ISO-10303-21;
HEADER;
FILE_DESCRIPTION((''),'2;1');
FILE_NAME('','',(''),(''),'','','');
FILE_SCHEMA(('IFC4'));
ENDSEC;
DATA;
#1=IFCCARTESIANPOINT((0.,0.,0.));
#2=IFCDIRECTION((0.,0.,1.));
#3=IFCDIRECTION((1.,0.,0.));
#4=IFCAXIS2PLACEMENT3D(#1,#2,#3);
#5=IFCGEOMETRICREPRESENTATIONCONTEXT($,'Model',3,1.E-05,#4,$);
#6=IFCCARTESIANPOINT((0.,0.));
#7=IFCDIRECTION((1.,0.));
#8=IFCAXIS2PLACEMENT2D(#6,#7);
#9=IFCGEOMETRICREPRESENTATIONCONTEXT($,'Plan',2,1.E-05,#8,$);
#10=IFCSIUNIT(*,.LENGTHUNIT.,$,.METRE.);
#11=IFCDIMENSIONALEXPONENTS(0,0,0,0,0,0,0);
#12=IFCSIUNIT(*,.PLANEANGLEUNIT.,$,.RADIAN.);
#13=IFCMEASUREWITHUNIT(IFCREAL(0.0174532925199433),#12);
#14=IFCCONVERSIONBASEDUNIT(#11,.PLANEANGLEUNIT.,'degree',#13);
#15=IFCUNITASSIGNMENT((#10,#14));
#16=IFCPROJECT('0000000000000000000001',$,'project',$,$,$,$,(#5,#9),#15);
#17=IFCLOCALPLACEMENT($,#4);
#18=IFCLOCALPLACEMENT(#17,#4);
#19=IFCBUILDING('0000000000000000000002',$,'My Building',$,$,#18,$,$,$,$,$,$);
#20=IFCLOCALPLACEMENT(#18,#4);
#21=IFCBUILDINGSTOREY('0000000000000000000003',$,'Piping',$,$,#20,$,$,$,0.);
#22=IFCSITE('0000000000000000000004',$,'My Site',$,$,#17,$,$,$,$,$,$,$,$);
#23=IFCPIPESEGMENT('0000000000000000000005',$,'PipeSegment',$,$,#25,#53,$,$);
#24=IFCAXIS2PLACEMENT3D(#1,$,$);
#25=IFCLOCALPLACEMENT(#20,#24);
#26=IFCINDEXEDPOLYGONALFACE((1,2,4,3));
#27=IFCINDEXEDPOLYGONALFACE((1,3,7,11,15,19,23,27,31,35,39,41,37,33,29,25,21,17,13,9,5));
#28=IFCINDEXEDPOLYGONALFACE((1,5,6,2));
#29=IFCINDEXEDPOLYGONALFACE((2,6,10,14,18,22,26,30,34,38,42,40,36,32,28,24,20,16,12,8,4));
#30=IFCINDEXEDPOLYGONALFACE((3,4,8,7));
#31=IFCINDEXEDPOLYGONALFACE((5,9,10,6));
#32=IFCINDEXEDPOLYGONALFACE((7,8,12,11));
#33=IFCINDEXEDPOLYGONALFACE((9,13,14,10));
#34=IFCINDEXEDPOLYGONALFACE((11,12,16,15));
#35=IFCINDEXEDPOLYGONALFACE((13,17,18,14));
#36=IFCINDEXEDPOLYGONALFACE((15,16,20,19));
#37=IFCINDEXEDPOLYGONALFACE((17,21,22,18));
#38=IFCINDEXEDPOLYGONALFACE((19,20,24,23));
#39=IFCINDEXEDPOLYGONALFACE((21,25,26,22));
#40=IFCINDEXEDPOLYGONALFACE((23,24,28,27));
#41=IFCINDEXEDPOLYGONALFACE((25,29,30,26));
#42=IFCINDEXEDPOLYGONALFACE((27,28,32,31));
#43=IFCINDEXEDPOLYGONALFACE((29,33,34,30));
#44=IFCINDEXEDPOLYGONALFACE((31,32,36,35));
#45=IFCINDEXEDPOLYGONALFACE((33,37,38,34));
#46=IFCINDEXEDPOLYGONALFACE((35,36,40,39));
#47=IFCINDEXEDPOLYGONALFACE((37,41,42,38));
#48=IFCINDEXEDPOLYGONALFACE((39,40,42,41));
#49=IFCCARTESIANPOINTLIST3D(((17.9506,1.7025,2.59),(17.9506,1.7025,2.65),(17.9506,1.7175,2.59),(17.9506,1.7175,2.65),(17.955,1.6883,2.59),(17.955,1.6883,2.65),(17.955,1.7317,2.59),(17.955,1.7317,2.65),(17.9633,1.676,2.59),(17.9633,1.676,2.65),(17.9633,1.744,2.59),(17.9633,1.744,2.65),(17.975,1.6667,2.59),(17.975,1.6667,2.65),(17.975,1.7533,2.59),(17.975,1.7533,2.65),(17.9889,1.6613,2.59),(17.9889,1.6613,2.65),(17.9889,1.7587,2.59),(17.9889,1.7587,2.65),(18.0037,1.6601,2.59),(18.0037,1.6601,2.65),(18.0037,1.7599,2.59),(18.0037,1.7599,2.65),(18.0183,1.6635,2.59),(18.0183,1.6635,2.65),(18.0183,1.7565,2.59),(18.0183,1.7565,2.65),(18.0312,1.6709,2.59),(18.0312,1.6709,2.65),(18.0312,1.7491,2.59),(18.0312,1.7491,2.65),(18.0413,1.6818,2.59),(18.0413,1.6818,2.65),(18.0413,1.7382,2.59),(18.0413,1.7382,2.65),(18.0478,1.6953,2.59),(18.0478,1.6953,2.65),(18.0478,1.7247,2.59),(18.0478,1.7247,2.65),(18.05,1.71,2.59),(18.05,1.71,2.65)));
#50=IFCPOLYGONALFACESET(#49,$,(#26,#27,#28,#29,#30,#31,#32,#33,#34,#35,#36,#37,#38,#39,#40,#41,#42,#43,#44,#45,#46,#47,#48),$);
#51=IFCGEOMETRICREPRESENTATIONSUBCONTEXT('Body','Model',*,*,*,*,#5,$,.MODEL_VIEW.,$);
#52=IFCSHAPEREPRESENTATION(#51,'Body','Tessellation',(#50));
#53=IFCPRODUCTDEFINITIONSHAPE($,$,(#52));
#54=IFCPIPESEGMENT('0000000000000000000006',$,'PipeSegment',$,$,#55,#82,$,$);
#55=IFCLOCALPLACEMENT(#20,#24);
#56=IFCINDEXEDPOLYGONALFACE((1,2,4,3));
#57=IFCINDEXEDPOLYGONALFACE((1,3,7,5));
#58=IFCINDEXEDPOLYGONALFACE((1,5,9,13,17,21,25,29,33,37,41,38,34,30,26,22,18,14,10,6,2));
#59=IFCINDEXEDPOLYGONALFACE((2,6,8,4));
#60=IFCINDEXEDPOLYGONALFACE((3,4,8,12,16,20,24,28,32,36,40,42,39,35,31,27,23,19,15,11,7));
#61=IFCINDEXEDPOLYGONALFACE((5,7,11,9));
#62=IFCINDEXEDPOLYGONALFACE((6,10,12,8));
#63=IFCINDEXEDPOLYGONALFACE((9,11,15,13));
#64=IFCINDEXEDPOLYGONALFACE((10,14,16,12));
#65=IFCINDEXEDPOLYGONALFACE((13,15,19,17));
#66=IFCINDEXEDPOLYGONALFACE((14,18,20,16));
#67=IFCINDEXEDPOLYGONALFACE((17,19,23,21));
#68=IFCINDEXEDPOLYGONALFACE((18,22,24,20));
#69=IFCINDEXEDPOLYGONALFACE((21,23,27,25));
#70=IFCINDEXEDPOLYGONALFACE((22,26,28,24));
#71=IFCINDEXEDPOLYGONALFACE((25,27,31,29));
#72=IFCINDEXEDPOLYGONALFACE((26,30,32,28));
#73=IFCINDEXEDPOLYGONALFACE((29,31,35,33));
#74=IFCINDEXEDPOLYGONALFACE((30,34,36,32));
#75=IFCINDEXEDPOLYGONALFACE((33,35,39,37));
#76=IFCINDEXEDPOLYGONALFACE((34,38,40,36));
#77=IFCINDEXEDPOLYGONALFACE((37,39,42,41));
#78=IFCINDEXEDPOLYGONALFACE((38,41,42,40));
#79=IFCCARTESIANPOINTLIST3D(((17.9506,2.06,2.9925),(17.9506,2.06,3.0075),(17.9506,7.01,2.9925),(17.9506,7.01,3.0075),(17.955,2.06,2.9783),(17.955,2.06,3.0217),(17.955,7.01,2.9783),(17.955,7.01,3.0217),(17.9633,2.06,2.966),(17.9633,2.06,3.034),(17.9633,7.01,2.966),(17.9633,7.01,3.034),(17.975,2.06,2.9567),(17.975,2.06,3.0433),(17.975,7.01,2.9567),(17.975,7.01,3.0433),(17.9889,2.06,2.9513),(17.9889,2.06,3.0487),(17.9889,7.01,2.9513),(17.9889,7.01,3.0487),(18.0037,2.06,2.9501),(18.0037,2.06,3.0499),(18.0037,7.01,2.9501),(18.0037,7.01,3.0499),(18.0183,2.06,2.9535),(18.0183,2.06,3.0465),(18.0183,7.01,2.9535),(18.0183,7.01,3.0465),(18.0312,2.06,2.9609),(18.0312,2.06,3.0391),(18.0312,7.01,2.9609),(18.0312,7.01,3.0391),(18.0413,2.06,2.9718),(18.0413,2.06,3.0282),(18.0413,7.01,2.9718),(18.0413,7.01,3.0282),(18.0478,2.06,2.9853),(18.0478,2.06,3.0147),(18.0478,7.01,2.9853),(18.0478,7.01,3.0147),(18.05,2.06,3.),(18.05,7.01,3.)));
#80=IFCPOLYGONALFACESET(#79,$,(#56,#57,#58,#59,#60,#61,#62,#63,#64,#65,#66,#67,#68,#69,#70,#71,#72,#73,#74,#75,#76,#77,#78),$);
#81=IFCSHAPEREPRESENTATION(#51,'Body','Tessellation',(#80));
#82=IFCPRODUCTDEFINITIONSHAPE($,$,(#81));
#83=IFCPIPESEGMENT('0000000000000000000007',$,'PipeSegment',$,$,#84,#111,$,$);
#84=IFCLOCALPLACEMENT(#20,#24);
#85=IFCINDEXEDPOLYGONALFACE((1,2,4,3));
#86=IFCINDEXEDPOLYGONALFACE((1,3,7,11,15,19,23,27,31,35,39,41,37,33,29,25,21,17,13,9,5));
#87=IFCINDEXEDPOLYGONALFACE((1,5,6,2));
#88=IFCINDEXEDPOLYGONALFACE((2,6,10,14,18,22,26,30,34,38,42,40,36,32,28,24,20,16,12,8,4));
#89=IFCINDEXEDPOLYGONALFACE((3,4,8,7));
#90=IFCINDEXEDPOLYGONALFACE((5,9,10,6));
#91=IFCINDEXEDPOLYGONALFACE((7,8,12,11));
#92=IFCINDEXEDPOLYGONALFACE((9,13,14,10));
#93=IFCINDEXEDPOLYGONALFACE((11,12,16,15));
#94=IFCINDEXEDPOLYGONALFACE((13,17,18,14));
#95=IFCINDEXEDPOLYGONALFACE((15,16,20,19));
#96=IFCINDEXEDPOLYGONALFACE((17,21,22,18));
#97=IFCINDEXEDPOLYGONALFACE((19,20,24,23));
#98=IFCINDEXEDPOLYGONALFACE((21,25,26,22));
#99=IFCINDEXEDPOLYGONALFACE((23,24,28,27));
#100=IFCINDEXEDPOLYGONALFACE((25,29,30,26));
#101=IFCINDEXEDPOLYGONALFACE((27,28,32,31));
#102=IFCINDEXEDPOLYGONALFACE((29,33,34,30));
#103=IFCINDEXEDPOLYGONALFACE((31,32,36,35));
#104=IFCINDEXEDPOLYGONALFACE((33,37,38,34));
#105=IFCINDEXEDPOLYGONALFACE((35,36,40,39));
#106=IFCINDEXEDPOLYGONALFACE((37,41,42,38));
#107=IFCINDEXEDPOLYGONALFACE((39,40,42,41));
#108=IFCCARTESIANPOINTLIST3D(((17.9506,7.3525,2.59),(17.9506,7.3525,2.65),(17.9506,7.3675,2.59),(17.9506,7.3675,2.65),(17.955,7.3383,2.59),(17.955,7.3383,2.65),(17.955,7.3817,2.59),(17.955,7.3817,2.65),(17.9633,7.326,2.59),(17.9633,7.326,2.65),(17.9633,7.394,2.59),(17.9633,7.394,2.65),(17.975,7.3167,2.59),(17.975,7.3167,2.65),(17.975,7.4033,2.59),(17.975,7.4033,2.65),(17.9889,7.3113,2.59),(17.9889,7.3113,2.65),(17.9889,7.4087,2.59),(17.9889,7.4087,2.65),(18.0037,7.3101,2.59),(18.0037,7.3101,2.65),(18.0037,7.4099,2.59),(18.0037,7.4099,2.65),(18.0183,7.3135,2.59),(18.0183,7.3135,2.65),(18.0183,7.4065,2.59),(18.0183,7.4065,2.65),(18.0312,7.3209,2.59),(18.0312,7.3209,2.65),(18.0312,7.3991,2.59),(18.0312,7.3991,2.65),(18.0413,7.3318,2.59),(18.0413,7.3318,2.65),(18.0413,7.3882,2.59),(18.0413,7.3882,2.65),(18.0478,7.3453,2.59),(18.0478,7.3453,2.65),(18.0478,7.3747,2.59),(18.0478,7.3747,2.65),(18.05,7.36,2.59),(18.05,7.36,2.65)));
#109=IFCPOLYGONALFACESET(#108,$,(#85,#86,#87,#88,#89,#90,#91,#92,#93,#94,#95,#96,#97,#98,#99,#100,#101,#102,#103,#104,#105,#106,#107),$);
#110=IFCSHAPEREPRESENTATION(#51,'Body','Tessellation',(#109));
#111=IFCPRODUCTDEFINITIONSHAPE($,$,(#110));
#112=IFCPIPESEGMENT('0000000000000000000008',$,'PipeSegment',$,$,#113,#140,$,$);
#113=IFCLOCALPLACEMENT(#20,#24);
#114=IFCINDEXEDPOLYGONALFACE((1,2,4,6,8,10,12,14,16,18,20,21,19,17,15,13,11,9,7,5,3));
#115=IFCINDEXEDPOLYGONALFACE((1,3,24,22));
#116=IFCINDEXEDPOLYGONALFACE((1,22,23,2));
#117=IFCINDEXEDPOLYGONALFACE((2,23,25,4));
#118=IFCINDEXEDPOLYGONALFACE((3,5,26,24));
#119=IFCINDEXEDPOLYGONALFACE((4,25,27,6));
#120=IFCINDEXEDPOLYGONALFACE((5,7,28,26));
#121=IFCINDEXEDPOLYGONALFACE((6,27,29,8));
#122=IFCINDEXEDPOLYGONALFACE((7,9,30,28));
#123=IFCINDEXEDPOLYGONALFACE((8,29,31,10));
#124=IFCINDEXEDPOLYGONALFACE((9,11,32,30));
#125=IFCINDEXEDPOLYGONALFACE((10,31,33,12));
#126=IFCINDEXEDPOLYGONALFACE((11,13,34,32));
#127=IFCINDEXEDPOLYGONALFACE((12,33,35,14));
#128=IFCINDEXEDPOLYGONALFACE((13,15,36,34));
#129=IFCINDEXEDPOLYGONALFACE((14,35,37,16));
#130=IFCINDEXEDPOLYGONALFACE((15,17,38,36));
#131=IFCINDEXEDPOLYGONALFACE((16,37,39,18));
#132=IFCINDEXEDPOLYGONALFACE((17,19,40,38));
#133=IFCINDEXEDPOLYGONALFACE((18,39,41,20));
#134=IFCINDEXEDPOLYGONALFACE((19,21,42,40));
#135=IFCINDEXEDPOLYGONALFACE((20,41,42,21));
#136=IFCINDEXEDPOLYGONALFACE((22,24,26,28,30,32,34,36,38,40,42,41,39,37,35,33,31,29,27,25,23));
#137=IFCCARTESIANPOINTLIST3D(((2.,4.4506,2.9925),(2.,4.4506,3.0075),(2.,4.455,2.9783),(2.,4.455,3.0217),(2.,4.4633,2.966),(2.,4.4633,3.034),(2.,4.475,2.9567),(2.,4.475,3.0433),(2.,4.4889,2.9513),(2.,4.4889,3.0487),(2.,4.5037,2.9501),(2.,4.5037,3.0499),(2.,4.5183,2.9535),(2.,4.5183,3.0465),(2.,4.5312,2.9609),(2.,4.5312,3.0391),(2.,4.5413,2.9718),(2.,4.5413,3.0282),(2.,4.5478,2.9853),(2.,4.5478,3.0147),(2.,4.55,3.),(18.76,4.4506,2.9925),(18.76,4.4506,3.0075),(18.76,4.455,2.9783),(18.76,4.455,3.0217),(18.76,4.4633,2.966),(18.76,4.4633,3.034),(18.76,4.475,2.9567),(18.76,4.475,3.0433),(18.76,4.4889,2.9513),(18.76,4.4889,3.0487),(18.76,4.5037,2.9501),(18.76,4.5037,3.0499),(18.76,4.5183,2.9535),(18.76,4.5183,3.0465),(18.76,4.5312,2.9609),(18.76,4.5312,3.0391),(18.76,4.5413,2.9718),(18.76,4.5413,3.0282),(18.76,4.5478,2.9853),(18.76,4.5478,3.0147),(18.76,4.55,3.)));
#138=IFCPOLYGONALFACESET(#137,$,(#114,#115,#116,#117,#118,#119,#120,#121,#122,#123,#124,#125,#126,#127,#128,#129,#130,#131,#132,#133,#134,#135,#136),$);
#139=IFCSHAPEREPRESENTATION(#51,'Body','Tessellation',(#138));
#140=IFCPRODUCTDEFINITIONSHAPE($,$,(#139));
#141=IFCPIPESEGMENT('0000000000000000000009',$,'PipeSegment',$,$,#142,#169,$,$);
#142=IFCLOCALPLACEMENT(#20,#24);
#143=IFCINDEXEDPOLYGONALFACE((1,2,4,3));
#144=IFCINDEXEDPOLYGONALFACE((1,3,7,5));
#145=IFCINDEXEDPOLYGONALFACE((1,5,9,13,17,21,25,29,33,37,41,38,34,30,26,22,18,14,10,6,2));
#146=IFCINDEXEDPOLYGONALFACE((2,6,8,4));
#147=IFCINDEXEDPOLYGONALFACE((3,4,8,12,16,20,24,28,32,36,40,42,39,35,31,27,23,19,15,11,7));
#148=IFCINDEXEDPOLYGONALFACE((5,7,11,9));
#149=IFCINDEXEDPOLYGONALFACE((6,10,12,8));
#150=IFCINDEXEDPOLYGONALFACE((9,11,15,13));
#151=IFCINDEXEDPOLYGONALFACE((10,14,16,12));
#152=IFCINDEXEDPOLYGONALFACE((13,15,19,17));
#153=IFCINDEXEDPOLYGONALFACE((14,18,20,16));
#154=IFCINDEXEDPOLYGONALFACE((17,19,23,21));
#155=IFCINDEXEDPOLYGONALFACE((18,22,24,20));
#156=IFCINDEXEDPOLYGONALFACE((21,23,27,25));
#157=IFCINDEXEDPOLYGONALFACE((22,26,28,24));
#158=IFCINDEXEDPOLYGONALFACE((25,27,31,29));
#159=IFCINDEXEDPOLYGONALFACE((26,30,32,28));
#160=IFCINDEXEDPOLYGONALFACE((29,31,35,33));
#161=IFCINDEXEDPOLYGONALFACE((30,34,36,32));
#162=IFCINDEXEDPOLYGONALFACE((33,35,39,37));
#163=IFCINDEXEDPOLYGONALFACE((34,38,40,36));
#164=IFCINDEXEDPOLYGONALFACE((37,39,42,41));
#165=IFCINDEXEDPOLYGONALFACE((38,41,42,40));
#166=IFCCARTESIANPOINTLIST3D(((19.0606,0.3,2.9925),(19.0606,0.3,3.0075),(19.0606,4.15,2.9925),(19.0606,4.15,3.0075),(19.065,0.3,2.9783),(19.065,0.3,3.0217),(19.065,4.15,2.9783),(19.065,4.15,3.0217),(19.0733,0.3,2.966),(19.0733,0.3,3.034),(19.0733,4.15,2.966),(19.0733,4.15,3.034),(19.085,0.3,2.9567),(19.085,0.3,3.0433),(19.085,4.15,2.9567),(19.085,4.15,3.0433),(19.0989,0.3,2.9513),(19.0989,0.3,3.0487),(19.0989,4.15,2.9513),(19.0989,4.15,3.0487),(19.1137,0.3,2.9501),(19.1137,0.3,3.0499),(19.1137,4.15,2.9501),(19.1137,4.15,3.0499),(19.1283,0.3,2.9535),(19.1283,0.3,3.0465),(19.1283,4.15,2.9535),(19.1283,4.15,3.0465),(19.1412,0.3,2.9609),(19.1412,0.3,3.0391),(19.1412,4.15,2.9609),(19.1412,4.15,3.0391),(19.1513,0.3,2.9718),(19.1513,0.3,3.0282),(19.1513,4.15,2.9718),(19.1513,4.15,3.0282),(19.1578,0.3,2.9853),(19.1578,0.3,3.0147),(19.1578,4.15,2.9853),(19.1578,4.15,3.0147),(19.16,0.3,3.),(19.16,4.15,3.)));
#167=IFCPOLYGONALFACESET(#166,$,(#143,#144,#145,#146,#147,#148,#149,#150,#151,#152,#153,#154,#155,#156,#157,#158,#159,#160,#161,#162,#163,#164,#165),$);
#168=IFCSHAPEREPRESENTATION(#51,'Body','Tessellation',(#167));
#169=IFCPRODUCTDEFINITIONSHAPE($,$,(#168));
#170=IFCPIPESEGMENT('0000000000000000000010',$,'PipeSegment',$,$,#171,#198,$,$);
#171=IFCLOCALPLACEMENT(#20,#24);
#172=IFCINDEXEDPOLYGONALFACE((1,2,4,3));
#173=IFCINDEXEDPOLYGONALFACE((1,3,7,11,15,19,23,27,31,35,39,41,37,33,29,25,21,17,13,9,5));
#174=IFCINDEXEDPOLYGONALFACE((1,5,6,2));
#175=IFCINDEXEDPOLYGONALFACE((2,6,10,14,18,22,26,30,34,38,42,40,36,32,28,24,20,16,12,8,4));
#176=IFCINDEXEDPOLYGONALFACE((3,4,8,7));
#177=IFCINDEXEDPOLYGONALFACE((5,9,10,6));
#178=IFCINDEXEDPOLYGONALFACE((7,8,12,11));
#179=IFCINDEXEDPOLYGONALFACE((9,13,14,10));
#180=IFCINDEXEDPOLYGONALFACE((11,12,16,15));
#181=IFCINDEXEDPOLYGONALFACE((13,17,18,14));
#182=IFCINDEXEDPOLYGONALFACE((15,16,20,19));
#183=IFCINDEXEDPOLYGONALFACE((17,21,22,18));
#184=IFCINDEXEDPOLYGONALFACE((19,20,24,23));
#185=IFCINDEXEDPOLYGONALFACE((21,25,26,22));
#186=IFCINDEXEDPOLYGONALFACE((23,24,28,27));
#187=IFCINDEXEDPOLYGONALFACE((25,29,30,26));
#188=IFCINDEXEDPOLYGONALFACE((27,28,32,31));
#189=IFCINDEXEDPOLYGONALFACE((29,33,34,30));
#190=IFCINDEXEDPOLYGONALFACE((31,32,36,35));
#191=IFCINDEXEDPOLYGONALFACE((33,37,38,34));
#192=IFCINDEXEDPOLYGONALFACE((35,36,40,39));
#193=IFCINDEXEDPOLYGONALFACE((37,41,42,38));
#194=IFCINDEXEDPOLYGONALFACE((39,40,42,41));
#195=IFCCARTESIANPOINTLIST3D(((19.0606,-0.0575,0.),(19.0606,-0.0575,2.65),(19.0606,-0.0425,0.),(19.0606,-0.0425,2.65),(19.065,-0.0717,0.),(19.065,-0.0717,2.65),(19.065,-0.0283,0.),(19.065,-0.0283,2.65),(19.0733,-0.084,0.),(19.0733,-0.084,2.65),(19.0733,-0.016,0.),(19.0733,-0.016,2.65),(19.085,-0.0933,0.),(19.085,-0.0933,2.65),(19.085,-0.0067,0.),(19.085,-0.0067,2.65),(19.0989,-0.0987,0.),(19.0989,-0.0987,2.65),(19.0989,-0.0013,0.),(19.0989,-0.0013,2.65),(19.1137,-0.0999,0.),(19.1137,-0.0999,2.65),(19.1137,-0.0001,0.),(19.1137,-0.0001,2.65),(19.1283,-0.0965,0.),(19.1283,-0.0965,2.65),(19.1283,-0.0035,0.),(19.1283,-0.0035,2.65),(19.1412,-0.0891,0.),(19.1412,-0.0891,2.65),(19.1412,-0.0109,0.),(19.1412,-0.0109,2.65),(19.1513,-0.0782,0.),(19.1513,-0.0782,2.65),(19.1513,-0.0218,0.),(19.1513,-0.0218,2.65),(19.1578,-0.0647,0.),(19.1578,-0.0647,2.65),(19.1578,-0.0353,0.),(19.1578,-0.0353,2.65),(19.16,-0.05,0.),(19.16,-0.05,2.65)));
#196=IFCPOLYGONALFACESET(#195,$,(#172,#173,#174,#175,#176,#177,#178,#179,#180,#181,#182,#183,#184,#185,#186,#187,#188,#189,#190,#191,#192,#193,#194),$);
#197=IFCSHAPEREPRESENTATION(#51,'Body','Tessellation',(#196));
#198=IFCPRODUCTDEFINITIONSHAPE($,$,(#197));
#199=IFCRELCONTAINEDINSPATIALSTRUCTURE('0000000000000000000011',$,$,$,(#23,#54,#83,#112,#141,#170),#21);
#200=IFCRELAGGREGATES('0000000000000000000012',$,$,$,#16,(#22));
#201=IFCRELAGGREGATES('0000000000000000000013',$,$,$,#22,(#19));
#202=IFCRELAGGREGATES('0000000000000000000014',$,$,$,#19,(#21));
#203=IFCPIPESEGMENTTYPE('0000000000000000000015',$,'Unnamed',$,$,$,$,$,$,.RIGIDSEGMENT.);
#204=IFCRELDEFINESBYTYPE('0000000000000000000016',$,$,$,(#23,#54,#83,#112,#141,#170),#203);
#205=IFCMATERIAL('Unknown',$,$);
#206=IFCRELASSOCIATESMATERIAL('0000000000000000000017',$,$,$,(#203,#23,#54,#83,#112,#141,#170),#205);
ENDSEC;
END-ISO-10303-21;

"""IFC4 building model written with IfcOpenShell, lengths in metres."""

from ifc_helpers import new_model, entity, si_unit, converted_unit, frame, origin_with_axes, origin_2d_with_axis, place, context, subcontext, project, spatial, circle, extrude, material, material_profile, profile_set, profile_usage, type_object, element, save


model = new_model("IFC4")

# Units and contexts
model_context = context("Model", 3, precision=1e-05, world=origin_with_axes())
plan_context = context("Plan", 2, precision=1e-05, world=origin_2d_with_axis())
body_context = subcontext(model_context, "Body", "Model", "MODEL_VIEW")
ifc_project = project(units=[si_unit("LENGTHUNIT", "METRE"), converted_unit("PLANEANGLEUNIT", "degree", entity("IfcReal", 0.0174532925199433), si_unit("PLANEANGLEUNIT", "RADIAN"), dimensions=[0, 0, 0, 0, 0, 0, 0])], contexts=[model_context, plan_context])

# Site, building, storey
site_placement = place(None, origin_with_axes())
site = spatial("IfcSite", under=ifc_project, at=site_placement, Name="My Site")
building_placement = place(site_placement, origin_with_axes())
building = spatial("IfcBuilding", under=site, at=building_placement, Name="My Building")
storey_placement = place(building_placement, origin_with_axes())
storey = spatial("IfcBuildingStorey", under=building, at=storey_placement, Name="Piping", Elevation=0.0)

# Pipe segments
ifc_material = material(Name="Unknown")
ifc_material_profile = material_profile(ifc_material, circle(Radius=0.05))
ifc_profile_set = profile_set([ifc_material_profile])
pipe_segment_type = type_object("IfcPipeSegmentType", Name="Unnamed", PredefinedType="RIGIDSEGMENT", material=ifc_profile_set)
ifc_profile_usage_1 = profile_usage(ifc_profile_set)
pipe_segment_1_placement = place(storey_placement, frame((18.0, 1.71, 2.59), z_axis=(0.0, 0.0, 1.0), x_axis=(1.0, 0.0, 0.0)))
element("IfcPipeSegment", 1, at=pipe_segment_1_placement, inside=storey, type_object=pipe_segment_type, material=ifc_profile_usage_1, Name="PipeSegment", context=body_context, shape_type="SweptSolid", body=[
    extrude(circle(Radius=0.05), origin_with_axes(), (0.0, 0.0, 1.0), 0.06),
])
ifc_profile_usage_2 = profile_usage(ifc_profile_set)
pipe_segment_2_placement = place(storey_placement, frame((18.0, 2.06, 3.0), z_axis=(0.0, 1.0, 0.0), x_axis=(1.0, 0.0, 0.0)))
element("IfcPipeSegment", 2, at=pipe_segment_2_placement, inside=storey, type_object=pipe_segment_type, material=ifc_profile_usage_2, Name="PipeSegment", context=body_context, shape_type="SweptSolid", body=[
    extrude(circle(Radius=0.05), origin_with_axes(), (0.0, 0.0, 1.0), 4.95),
])
ifc_profile_usage_3 = profile_usage(ifc_profile_set)
pipe_segment_3_placement = place(storey_placement, frame((18.0, 7.36, 2.65), z_axis=(0.0, 0.0, -1.0), x_axis=(1.0, 0.0, 0.0)))
element("IfcPipeSegment", 3, at=pipe_segment_3_placement, inside=storey, type_object=pipe_segment_type, material=ifc_profile_usage_3, Name="PipeSegment", context=body_context, shape_type="SweptSolid", body=[
    extrude(circle(Radius=0.05), origin_with_axes(), (0.0, 0.0, 1.0), 0.06),
])
ifc_profile_usage_4 = profile_usage(ifc_profile_set)
pipe_segment_4_placement = place(storey_placement, frame((2.0, 4.5, 3.0), z_axis=(1.0, 0.0, 0.0), x_axis=(0.0, 1.0, 0.0)))
element("IfcPipeSegment", 4, at=pipe_segment_4_placement, inside=storey, type_object=pipe_segment_type, material=ifc_profile_usage_4, Name="PipeSegment", context=body_context, shape_type="SweptSolid", body=[
    extrude(circle(Radius=0.05), origin_with_axes(), (0.0, 0.0, 1.0), 16.76),
])
ifc_profile_usage_5 = profile_usage(ifc_profile_set)
pipe_segment_5_placement = place(storey_placement, frame((19.11, 4.15, 3.0), z_axis=(0.0, -1.0, 0.0), x_axis=(1.0, 0.0, 0.0)))
element("IfcPipeSegment", 5, at=pipe_segment_5_placement, inside=storey, type_object=pipe_segment_type, material=ifc_profile_usage_5, Name="PipeSegment", context=body_context, shape_type="SweptSolid", body=[
    extrude(circle(Radius=0.05), origin_with_axes(), (0.0, 0.0, 1.0), 3.85),
])
ifc_profile_usage_6 = profile_usage(ifc_profile_set)
pipe_segment_6_placement = place(storey_placement, frame((19.11, -0.05, 2.65), z_axis=(0.0, 0.0, -1.0), x_axis=(1.0, 0.0, 0.0)))
element("IfcPipeSegment", 6, at=pipe_segment_6_placement, inside=storey, type_object=pipe_segment_type, material=ifc_profile_usage_6, Name="PipeSegment", context=body_context, shape_type="SweptSolid", body=[
    extrude(circle(Radius=0.05), origin_with_axes(), (0.0, 0.0, 1.0), 2.65),
])

save(model, "model.ifc")
